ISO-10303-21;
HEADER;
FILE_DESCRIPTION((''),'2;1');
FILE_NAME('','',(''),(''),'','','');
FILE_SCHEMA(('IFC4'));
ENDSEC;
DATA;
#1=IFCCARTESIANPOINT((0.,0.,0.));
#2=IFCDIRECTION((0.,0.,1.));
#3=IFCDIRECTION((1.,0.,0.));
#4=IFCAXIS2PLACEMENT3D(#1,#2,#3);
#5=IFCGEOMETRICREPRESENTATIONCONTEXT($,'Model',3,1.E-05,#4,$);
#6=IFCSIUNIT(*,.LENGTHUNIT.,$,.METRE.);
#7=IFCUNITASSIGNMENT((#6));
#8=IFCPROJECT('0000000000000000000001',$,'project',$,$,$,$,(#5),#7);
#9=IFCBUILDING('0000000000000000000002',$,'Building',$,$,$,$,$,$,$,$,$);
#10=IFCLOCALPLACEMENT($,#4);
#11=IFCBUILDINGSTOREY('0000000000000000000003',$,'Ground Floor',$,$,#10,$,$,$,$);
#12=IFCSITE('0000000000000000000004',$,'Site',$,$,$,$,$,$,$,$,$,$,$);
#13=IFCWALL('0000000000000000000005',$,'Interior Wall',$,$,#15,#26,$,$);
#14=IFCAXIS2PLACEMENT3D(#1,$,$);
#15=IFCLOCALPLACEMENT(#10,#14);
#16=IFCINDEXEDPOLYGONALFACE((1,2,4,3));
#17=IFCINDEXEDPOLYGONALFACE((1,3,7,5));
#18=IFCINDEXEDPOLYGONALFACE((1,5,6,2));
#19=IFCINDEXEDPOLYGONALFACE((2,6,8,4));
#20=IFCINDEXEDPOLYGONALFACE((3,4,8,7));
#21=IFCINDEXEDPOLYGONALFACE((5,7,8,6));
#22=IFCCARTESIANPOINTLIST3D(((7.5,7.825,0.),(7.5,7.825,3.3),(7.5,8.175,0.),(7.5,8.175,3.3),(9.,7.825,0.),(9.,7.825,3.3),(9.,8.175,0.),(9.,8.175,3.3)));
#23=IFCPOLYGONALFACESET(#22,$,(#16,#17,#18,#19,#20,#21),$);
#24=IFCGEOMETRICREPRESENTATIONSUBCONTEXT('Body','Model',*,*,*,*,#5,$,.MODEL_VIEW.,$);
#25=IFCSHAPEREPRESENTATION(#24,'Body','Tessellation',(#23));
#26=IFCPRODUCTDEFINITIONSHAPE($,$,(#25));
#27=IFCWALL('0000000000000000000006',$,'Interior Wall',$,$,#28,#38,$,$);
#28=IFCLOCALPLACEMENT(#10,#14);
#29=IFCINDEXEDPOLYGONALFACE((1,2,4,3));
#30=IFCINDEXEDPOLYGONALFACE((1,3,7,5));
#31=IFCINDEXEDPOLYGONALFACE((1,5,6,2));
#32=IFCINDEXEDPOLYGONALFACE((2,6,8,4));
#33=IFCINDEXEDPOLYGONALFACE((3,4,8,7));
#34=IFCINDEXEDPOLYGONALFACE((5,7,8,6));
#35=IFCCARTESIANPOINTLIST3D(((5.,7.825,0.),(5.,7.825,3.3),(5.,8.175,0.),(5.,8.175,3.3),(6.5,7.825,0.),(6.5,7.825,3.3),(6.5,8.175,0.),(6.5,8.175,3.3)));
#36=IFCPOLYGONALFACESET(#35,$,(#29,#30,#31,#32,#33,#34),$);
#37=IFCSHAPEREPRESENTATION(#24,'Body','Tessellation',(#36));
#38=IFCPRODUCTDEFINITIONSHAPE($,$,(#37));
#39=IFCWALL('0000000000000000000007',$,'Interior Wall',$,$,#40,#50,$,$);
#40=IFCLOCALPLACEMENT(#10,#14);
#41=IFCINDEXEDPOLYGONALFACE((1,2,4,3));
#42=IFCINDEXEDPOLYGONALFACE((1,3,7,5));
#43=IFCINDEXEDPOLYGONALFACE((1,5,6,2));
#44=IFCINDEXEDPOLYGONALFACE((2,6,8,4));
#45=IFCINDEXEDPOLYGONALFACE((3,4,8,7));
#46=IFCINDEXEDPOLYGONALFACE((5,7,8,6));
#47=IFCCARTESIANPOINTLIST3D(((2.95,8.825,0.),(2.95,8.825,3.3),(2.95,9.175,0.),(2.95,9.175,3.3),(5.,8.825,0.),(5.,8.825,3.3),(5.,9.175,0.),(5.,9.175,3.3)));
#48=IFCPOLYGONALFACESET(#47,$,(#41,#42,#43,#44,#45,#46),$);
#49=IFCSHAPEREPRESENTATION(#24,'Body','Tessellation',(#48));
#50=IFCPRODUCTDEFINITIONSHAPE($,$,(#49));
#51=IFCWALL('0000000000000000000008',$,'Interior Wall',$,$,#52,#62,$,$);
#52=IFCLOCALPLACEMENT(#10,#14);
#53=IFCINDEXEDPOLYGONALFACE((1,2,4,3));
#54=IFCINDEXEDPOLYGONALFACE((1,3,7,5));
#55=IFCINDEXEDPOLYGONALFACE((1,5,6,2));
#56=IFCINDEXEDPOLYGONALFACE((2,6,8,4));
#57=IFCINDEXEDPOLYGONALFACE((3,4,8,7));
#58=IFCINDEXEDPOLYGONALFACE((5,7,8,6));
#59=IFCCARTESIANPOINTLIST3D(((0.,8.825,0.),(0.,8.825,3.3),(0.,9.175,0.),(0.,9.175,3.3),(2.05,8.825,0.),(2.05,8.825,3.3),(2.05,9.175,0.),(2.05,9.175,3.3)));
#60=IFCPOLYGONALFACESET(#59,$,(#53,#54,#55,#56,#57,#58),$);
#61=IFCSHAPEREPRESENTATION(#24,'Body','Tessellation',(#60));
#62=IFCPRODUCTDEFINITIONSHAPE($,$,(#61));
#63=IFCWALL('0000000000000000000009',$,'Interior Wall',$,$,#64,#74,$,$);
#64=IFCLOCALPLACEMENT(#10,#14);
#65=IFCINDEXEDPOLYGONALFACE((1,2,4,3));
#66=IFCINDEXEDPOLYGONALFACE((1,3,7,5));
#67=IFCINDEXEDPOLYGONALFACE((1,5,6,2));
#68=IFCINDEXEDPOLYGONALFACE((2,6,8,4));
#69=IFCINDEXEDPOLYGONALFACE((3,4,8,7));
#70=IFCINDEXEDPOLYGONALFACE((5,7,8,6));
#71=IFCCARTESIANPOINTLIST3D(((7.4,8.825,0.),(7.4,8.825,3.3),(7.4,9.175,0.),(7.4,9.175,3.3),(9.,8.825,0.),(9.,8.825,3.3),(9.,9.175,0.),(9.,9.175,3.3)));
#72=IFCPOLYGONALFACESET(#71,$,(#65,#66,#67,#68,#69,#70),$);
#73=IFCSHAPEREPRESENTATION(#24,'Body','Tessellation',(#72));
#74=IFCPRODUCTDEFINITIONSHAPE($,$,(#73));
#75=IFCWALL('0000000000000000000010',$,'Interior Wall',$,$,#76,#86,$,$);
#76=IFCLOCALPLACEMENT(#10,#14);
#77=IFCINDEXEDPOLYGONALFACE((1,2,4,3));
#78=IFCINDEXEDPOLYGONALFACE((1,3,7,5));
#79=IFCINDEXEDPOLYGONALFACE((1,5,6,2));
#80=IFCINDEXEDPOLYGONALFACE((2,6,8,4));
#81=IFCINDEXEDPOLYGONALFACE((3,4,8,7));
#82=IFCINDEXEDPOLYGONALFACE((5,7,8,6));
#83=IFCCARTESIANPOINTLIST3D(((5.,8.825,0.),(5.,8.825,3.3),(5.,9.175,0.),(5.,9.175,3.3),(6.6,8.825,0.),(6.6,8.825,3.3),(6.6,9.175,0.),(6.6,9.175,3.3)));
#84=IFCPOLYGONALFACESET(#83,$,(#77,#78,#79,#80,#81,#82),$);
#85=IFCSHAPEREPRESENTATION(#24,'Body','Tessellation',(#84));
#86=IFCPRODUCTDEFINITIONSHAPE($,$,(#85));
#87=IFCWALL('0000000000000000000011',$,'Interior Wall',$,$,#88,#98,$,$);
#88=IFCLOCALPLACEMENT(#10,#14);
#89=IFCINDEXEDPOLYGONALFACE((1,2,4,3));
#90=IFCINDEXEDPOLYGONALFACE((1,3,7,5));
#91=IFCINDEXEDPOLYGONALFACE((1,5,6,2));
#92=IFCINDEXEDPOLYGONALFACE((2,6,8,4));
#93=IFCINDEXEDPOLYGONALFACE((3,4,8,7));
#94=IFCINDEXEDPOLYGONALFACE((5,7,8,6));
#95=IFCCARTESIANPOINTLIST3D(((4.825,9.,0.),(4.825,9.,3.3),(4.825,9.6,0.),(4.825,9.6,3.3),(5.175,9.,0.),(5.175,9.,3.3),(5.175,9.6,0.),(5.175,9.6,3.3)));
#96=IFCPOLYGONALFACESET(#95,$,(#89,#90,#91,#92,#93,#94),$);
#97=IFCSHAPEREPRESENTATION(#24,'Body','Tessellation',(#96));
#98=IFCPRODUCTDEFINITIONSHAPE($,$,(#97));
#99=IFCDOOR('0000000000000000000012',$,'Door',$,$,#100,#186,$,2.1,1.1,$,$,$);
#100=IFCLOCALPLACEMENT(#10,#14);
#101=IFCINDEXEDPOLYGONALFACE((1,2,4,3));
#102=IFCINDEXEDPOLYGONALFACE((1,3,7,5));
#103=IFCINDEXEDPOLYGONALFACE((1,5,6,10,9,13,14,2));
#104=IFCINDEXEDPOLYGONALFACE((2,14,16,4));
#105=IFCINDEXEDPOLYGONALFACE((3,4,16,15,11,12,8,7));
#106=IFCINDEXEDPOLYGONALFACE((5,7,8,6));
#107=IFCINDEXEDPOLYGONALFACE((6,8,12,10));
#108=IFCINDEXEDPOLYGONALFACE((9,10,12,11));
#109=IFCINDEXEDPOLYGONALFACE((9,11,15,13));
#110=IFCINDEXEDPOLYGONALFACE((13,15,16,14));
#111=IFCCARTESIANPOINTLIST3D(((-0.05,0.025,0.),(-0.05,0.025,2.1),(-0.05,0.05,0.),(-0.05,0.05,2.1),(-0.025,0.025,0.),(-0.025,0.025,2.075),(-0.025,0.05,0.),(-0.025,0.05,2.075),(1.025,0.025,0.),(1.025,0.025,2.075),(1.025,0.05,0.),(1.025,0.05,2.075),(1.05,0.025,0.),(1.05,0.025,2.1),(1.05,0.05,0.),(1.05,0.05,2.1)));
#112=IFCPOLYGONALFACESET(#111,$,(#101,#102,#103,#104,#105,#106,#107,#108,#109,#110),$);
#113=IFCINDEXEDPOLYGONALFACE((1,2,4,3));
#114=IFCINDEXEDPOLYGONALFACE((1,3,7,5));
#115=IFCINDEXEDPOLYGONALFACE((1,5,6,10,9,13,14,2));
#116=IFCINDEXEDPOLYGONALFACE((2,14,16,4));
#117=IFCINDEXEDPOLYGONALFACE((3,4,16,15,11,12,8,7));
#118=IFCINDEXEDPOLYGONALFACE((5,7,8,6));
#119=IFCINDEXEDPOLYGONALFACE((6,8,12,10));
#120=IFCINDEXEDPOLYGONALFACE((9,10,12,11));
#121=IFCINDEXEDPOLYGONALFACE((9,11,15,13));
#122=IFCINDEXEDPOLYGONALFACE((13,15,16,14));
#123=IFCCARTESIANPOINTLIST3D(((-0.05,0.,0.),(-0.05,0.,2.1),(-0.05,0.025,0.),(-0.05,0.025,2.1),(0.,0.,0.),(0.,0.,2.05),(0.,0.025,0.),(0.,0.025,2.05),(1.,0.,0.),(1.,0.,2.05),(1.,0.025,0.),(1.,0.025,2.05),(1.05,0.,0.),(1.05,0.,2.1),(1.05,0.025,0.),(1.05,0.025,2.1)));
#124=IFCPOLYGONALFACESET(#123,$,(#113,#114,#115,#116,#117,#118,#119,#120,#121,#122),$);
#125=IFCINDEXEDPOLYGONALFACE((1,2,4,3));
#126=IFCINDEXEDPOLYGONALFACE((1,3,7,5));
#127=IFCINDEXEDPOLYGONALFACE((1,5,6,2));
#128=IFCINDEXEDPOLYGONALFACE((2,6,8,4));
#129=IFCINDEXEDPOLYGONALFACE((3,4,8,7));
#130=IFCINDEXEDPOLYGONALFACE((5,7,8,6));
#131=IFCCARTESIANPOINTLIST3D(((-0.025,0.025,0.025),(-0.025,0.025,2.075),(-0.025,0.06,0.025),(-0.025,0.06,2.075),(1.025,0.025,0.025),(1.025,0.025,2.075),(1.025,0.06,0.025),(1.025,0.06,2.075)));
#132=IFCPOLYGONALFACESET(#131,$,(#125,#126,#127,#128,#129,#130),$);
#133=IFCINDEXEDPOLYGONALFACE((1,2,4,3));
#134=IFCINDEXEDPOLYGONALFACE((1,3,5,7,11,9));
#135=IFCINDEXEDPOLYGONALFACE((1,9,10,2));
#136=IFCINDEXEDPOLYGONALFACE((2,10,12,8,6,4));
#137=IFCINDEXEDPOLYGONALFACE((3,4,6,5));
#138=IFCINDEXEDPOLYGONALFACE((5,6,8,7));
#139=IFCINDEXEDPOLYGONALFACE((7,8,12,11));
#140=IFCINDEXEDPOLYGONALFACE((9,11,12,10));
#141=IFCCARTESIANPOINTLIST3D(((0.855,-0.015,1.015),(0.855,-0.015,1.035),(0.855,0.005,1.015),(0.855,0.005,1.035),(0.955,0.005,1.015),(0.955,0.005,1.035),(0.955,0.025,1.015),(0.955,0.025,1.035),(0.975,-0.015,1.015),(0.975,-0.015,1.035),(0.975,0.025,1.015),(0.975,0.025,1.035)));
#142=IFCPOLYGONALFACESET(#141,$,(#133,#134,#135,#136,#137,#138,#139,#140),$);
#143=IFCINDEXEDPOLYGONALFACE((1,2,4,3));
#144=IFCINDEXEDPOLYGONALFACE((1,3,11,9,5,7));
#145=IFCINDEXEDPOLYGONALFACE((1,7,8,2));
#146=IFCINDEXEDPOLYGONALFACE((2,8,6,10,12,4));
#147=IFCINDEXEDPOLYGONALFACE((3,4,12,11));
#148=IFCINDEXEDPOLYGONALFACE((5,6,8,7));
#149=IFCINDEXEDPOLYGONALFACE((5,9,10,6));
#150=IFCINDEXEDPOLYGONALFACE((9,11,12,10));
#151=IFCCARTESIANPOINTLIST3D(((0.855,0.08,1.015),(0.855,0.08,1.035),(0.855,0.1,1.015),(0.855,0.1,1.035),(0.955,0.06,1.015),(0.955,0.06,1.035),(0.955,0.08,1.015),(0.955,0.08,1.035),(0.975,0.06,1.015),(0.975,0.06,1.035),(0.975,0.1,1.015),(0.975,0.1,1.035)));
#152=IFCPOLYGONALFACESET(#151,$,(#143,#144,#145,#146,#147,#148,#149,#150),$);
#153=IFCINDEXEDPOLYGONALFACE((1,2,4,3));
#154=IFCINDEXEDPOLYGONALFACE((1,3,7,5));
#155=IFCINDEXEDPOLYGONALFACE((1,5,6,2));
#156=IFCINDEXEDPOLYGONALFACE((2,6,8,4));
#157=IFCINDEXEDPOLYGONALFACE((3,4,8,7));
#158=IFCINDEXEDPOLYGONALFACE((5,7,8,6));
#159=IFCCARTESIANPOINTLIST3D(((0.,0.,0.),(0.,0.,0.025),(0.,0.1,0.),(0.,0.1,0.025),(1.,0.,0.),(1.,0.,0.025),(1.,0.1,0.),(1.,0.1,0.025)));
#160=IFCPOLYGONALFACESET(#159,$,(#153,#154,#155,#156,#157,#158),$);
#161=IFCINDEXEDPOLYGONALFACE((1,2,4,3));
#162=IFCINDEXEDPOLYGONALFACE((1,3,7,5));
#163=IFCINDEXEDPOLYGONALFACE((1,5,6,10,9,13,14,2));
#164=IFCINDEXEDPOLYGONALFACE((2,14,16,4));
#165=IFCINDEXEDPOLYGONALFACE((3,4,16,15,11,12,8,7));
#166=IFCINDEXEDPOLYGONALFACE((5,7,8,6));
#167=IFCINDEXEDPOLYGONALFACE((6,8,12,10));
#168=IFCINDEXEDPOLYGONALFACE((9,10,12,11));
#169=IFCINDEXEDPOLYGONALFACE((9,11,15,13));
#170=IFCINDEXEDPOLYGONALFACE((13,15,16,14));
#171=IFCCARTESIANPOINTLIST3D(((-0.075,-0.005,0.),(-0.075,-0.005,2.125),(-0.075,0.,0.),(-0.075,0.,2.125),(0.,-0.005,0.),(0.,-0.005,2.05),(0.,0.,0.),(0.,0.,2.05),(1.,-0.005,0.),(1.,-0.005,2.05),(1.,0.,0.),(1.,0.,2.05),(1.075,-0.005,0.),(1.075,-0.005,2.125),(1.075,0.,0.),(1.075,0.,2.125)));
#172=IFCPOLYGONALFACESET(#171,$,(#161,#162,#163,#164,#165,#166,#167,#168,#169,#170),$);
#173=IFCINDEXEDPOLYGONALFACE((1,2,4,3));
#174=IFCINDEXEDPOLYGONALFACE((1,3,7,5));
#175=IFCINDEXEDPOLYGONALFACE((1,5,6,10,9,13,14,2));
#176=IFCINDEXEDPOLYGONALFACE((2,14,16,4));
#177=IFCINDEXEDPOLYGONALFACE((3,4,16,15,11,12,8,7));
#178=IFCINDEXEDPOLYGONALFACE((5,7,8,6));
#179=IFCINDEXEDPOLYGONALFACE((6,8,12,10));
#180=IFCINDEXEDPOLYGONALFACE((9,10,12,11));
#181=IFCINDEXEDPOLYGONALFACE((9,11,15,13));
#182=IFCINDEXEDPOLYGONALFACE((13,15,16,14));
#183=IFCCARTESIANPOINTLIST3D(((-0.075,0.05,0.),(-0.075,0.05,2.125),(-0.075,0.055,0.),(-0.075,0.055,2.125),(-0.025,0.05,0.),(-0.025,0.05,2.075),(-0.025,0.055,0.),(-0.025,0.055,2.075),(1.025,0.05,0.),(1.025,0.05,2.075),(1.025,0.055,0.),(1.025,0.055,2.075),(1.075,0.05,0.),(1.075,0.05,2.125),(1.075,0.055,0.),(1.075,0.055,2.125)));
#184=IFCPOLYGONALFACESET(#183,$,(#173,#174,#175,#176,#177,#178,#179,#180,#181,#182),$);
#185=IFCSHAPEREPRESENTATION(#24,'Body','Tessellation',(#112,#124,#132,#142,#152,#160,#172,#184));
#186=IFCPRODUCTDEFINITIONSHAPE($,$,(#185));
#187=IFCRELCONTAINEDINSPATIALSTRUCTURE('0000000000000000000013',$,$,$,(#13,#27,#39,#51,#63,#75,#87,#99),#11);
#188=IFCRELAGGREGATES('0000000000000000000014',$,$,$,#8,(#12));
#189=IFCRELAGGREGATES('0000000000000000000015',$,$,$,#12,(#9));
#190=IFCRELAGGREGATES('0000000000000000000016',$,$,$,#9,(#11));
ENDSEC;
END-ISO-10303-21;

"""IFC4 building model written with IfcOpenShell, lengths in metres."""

from ifc_helpers import new_model, si_unit, frame, origin_with_axes, place, context, subcontext, project, spatial, line, indexed_curve, outline, extrude, element, save


model = new_model("IFC4")

# Units and contexts
model_context = context("Model", 3, precision=1e-05, world=origin_with_axes())
body_context = subcontext(model_context, "Body", "Model", "MODEL_VIEW")
ifc_project = project(units=[si_unit("LENGTHUNIT", "METRE")], contexts=[model_context])

# Site, building, storey
site = spatial("IfcSite", under=ifc_project, Name="Site")
building = spatial("IfcBuilding", under=site, Name="Building")
storey_placement = place(None, origin_with_axes())
storey = spatial("IfcBuildingStorey", under=building, at=storey_placement, Name="Ground Floor")

# Walls
for number, where, z_axis, x_axis, name in (
    (1, (9.0, 8.0, 0.0), (0.0, 0.0, 1.0), (-1.0, 0.0, 0.0), "Interior Wall"),
    (2, (6.5, 8.0, 0.0), (0.0, 0.0, 1.0), (-1.0, 0.0, 0.0), "Interior Wall"),
):
    element("IfcWall", number, at=place(storey_placement, frame(where, z_axis=z_axis, x_axis=x_axis)), inside=storey, Name=name, context=body_context, shape_type="SweptSolid", body=[
        extrude(outline(indexed_curve([(0.0, 0.0), (0.0, 0.35), (1.5, 0.35), (1.5, 0.0), (0.0, 0.0)], self_intersect=False)), frame((0.0, -0.175, 0.0), z_axis=(0.0, 0.0, 1.0), x_axis=(1.0, 0.0, 0.0)), (0.0, 0.0, 1.0), 3.3),
    ])
for number, where, z_axis, x_axis, name in (
    (3, (5.0, 9.0, 0.0), (0.0, 0.0, 1.0), (-1.0, 0.0, 0.0), "Interior Wall"),
    (4, (2.05, 9.0, 0.0), (0.0, 0.0, 1.0), (-1.0, 0.0, 0.0), "Interior Wall"),
):
    element("IfcWall", number, at=place(storey_placement, frame(where, z_axis=z_axis, x_axis=x_axis)), inside=storey, Name=name, context=body_context, shape_type="SweptSolid", body=[
        extrude(outline(indexed_curve([(0.0, 0.0), (0.0, 0.35), (2.05, 0.35), (2.05, 0.0), (0.0, 0.0)], self_intersect=False)), frame((0.0, -0.175, 0.0), z_axis=(0.0, 0.0, 1.0), x_axis=(1.0, 0.0, 0.0)), (0.0, 0.0, 1.0), 3.3),
    ])
for number, where, z_axis, x_axis, name in (
    (5, (9.0, 9.0, 0.0), (0.0, 0.0, 1.0), (-1.0, 0.0, 0.0), "Interior Wall"),
    (6, (6.6, 9.0, 0.0), (0.0, 0.0, 1.0), (-1.0, 0.0, 0.0), "Interior Wall"),
):
    element("IfcWall", number, at=place(storey_placement, frame(where, z_axis=z_axis, x_axis=x_axis)), inside=storey, Name=name, context=body_context, shape_type="SweptSolid", body=[
        extrude(outline(indexed_curve([(0.0, 0.0), (0.0, 0.35), (1.6, 0.35), (1.6, 0.0), (0.0, 0.0)], self_intersect=False)), frame((0.0, -0.175, 0.0), z_axis=(0.0, 0.0, 1.0), x_axis=(1.0, 0.0, 0.0)), (0.0, 0.0, 1.0), 3.3),
    ])
wall_1_placement = place(storey_placement, frame((5.0, 9.0, 0.0), z_axis=(0.0, 0.0, 1.0), x_axis=(0.0, 1.0, 0.0)))
element("IfcWall", 7, at=wall_1_placement, inside=storey, Name="Interior Wall", context=body_context, shape_type="SweptSolid", body=[
    extrude(outline(indexed_curve([(0.0, 0.0), (0.0, 0.35), (0.6, 0.35), (0.6, 0.0), (0.0, 0.0)], self_intersect=False)), frame((0.0, -0.175, 0.0), z_axis=(0.0, 0.0, 1.0), x_axis=(1.0, 0.0, 0.0)), (0.0, 0.0, 1.0), 3.3),
])

# Door
door_1_placement = place(storey_placement, frame((-0.05, 0.0, 0.0), z_axis=(0.0, 0.0, 1.0), x_axis=(1.0, 0.0, 0.0)))
element("IfcDoor", 8, at=door_1_placement, inside=storey, Name="Door", OverallHeight=2.1, OverallWidth=1.1, context=body_context, shape_type="SweptSolid", body=[
    extrude(outline(indexed_curve([(0.0, 0.0), (0.0, 2.1), (1.1, 2.1), (1.1, 0.0), (1.075, 0.0), (1.075, 2.075), (0.025, 2.075), (0.025, 0.0)], segments=[line(1, 2, 3, 4, 5, 6, 7, 8, 1)])), frame((0.0, 0.025, 0.0), z_axis=(0.0, -1.0, 0.0), x_axis=(1.0, 0.0, 0.0)), (0.0, 0.0, -1.0), 0.025),
    extrude(outline(indexed_curve([(0.0, 0.0), (0.0, 2.1), (1.1, 2.1), (1.1, 0.0), (1.05, 0.0), (1.05, 2.05), (0.05, 2.05), (0.05, 0.0)], segments=[line(1, 2, 3, 4, 5, 6, 7, 8, 1)])), frame((0.0, 0.0, 0.0), z_axis=(0.0, -1.0, 0.0), x_axis=(1.0, 0.0, 0.0)), (0.0, 0.0, -1.0), 0.025),
    extrude(outline(indexed_curve([(0.0, 0.0), (1.05, 0.0), (1.05, 0.035), (0.0, 0.035)], segments=[line(1, 2, 3, 4, 1)])), frame((0.025, 0.025, 0.025), z_axis=(0.0, 0.0, 1.0), x_axis=(1.0, 0.0, 0.0)), (0.0, 0.0, 1.0), 2.05),
    extrude(outline(indexed_curve([(0.0, 0.0), (0.0, -0.04), (-0.12, -0.04), (-0.12, -0.02), (-0.02, -0.02), (-0.02, 0.0)], segments=[line(1, 2, 3, 4, 5, 6, 1)])), frame((1.025, 0.025, 1.015), z_axis=(0.0, 0.0, 1.0), x_axis=(1.0, 0.0, 0.0)), (0.0, 0.0, 1.0), 0.02),
    extrude(outline(indexed_curve([(0.0, 0.0), (0.0, 0.04), (-0.12, 0.04), (-0.12, 0.02), (-0.02, 0.02), (-0.02, 0.0)], segments=[line(1, 2, 3, 4, 5, 6, 1)])), frame((1.025, 0.06, 1.015), z_axis=(0.0, 0.0, 1.0), x_axis=(1.0, 0.0, 0.0)), (0.0, 0.0, 1.0), 0.02),
    extrude(outline(indexed_curve([(0.0, 0.0), (1.0, 0.0), (1.0, 0.1), (0.0, 0.1)], segments=[line(1, 2, 3, 4, 1)])), frame((0.05, 0.0, 0.0), z_axis=(0.0, 0.0, 1.0), x_axis=(1.0, 0.0, 0.0)), (0.0, 0.0, 1.0), 0.025),
    extrude(outline(indexed_curve([(0.0, 0.0), (0.0, 2.125), (1.15, 2.125), (1.15, 0.0), (1.075, 0.0), (1.075, 2.05), (0.075, 2.05), (0.075, 0.0)], segments=[line(1, 2, 3, 4, 5, 6, 7, 8, 1)])), frame((-0.025, -0.005, 0.0), z_axis=(0.0, -1.0, 0.0), x_axis=(1.0, 0.0, 0.0)), (0.0, 0.0, -1.0), 0.005),
    extrude(outline(indexed_curve([(0.0, 0.0), (0.0, 2.125), (1.15, 2.125), (1.15, 0.0), (1.1, 0.0), (1.1, 2.075), (0.05, 2.075), (0.05, 0.0)], segments=[line(1, 2, 3, 4, 5, 6, 7, 8, 1)])), frame((-0.025, 0.05, 0.0), z_axis=(0.0, -1.0, 0.0), x_axis=(1.0, 0.0, 0.0)), (0.0, 0.0, -1.0), 0.005),
])

save(model, "model.ifc")
